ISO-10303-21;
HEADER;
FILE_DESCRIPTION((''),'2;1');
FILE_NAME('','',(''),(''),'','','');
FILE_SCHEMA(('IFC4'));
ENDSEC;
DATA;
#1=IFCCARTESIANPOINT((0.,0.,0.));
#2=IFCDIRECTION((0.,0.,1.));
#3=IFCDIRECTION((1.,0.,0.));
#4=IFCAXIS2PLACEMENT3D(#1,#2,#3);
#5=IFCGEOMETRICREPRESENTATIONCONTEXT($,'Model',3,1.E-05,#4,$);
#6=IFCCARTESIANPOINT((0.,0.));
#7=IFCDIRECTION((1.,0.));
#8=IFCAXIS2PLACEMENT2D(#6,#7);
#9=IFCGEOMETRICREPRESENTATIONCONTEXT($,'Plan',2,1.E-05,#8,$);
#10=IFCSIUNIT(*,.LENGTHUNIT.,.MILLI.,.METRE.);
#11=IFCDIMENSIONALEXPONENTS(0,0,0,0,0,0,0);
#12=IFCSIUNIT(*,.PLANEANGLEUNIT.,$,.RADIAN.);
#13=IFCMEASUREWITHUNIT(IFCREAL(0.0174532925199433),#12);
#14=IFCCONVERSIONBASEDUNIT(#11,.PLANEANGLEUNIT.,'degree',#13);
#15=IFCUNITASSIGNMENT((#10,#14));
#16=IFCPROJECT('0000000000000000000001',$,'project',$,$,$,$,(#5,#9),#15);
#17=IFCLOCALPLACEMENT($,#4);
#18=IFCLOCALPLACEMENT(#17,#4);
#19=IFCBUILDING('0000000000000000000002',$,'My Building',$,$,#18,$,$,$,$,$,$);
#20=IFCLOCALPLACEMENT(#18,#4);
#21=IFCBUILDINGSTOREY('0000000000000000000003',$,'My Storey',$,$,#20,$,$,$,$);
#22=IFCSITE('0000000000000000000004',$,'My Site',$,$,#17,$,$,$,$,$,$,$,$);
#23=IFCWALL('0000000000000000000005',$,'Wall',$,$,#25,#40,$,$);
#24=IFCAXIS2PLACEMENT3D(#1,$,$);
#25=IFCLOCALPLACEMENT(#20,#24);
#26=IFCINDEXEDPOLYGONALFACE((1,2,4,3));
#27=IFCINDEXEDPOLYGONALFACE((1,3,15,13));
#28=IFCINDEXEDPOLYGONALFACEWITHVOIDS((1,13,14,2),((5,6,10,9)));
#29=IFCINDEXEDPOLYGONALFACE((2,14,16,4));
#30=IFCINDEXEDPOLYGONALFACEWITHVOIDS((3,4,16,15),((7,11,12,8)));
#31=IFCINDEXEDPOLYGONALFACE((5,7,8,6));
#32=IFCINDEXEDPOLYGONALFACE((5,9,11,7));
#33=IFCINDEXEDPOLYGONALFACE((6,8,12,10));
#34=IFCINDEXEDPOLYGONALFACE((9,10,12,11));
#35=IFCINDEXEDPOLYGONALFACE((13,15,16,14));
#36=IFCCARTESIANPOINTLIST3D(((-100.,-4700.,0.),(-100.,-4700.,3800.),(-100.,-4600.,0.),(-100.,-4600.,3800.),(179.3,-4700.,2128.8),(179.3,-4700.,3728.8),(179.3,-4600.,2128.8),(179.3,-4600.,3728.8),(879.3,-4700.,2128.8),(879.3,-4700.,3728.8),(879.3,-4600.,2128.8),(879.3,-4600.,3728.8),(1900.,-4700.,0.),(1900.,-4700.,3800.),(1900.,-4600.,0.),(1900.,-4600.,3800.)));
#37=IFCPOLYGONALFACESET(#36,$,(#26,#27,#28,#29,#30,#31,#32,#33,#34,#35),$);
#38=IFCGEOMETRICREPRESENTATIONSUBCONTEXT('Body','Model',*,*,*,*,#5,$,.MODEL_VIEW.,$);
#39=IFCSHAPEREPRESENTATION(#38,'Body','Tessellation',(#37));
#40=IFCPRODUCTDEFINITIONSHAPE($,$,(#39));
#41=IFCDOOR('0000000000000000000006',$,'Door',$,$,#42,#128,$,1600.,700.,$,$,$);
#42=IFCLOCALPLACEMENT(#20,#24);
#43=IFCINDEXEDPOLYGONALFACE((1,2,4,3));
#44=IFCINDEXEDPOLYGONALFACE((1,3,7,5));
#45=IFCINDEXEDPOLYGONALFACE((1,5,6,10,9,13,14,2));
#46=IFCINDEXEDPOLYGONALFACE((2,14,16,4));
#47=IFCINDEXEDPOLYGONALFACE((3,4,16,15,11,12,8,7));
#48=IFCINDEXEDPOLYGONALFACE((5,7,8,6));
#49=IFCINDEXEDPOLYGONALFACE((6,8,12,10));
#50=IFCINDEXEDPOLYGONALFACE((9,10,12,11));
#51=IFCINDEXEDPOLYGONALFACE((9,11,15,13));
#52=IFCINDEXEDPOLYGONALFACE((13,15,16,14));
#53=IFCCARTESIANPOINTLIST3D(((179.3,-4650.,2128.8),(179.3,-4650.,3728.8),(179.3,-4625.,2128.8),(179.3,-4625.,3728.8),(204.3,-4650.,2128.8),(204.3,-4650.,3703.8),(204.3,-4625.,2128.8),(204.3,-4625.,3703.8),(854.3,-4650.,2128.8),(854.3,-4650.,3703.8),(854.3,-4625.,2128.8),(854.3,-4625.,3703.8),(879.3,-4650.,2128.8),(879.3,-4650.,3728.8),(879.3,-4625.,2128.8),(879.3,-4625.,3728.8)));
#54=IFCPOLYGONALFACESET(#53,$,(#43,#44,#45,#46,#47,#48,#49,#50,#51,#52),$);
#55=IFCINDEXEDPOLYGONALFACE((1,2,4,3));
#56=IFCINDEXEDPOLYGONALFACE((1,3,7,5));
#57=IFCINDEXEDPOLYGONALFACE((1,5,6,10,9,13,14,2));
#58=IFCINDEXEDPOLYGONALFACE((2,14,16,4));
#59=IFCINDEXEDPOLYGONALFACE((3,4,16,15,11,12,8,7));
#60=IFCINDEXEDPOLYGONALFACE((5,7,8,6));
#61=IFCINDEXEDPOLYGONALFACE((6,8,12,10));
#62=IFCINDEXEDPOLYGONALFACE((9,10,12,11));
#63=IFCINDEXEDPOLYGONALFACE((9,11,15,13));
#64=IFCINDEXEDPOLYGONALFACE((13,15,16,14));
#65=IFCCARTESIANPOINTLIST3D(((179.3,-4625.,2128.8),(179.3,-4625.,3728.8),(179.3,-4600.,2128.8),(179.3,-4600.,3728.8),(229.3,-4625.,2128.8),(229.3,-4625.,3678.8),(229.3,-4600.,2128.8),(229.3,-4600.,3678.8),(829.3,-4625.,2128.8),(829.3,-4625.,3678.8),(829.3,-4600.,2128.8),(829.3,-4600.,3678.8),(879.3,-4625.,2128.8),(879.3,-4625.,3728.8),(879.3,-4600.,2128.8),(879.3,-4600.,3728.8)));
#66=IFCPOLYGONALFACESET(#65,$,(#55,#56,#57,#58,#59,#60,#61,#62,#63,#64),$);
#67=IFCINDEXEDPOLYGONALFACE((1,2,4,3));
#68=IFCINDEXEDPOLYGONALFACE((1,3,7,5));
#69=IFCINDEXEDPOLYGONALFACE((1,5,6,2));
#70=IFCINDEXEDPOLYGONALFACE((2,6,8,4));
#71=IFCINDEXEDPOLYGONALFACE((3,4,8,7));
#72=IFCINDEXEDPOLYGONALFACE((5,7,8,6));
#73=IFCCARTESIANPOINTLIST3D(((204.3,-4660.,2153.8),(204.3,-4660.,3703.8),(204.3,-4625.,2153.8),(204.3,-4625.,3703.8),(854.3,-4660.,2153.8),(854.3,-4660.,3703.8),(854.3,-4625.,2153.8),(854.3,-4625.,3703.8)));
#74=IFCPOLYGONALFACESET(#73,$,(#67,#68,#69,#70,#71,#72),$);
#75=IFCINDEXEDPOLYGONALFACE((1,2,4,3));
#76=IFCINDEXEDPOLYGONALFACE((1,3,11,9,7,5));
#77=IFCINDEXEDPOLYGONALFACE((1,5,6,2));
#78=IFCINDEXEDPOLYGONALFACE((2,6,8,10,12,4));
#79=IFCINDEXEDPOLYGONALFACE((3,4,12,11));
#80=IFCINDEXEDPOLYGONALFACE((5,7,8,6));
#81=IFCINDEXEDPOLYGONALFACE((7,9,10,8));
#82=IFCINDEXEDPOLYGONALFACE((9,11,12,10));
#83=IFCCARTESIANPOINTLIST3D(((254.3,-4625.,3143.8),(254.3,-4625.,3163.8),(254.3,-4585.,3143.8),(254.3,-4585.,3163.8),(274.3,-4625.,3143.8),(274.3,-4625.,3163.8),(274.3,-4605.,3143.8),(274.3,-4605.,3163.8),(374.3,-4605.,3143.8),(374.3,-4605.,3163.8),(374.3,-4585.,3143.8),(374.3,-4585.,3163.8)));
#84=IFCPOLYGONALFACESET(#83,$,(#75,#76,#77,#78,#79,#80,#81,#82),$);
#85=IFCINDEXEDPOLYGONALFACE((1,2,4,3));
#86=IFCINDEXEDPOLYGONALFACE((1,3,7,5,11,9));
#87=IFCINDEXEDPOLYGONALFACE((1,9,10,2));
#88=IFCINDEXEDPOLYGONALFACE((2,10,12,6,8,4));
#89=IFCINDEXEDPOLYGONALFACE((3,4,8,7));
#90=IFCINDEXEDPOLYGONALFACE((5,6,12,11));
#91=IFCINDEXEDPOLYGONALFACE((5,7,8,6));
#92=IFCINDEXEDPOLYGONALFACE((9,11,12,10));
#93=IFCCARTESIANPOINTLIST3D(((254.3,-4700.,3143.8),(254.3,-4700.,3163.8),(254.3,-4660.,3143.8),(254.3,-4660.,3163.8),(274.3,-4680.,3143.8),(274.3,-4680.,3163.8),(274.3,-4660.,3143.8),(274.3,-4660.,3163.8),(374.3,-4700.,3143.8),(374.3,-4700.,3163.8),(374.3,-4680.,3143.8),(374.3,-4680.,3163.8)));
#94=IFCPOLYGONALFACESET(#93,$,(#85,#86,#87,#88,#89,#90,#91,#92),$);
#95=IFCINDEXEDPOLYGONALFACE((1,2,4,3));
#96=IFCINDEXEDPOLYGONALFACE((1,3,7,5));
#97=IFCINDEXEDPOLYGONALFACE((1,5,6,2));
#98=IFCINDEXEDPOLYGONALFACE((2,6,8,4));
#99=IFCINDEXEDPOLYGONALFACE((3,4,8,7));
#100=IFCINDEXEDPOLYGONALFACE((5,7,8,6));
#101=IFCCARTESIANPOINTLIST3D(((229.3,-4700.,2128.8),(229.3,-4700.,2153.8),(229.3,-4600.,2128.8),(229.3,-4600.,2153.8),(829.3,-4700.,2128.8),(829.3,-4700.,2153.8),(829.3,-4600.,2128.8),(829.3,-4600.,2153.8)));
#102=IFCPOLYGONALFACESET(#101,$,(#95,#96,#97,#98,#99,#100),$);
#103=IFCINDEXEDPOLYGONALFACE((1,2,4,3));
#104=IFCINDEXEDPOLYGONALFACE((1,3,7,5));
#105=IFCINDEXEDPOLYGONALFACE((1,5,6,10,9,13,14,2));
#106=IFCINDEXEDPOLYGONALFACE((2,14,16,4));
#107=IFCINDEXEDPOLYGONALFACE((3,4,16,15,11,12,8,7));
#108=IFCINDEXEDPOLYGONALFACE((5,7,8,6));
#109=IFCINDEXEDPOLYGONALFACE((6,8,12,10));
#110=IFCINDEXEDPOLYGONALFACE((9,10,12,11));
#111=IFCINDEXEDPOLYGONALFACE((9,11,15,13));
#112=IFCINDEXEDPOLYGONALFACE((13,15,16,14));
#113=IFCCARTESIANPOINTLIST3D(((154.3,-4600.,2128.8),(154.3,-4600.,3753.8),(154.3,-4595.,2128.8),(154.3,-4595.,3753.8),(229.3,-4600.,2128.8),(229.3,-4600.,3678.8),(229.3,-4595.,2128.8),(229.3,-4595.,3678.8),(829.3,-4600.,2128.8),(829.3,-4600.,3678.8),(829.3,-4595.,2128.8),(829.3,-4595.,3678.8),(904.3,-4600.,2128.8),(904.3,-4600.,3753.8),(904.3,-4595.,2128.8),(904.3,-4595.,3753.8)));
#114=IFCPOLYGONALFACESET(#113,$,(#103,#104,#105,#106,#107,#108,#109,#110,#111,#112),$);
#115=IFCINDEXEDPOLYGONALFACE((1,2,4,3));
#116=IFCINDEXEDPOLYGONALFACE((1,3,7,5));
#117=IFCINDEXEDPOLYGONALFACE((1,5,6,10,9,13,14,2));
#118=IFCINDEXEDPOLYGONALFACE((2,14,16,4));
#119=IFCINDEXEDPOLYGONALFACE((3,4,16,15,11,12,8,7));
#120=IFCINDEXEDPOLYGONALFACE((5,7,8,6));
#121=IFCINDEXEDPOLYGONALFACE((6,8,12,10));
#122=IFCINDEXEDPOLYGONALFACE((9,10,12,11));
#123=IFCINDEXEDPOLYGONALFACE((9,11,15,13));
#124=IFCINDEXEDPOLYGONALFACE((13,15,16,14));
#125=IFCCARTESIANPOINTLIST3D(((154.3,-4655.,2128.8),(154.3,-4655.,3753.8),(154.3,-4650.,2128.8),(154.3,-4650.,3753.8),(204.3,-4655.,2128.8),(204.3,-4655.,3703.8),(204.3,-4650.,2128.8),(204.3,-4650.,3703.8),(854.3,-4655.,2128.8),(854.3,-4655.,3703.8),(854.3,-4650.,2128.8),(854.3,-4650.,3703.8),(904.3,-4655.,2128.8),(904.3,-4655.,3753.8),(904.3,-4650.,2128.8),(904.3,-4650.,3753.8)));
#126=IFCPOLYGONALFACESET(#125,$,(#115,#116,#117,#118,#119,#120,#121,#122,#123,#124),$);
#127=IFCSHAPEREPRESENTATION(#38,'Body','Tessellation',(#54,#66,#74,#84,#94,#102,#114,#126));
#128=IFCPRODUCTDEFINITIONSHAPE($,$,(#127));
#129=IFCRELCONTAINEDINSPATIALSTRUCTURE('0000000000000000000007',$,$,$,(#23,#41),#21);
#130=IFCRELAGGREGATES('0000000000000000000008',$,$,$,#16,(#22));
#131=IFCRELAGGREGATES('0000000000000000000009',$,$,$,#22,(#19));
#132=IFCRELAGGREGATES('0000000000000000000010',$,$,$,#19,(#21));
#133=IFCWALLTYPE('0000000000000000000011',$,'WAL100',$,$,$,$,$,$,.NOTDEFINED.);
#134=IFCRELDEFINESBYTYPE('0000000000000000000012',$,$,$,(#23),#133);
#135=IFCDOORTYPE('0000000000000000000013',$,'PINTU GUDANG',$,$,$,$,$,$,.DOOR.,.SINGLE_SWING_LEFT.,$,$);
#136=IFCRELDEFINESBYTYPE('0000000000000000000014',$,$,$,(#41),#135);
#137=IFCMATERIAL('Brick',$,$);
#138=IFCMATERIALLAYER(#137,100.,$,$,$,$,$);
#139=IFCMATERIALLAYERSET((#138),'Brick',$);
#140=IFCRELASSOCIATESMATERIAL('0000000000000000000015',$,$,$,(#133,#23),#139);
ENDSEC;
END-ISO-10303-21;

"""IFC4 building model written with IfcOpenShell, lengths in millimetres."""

from ifc_helpers import new_model, entity, si_unit, converted_unit, frame, origin_with_axes, origin_2d_with_axis, place, context, subcontext, project, spatial, line, indexed_curve, outline, extrude, shape, source, transform, mapped, material, layer, layer_set, layer_usage, type_object, type_shapes, element, fill, save


model = new_model("IFC4")

# Units and contexts
model_context = context("Model", 3, precision=1e-05, world=origin_with_axes())
plan_context = context("Plan", 2, precision=1e-05, world=origin_2d_with_axis())
body_context_1 = subcontext(model_context, "Body", "Model", "MODEL_VIEW")
body_context_2 = subcontext(plan_context, "Body", "Plan", "PLAN_VIEW")
ifc_project = project(units=[si_unit("LENGTHUNIT", "METRE", prefix="MILLI"), converted_unit("PLANEANGLEUNIT", "degree", entity("IfcReal", 0.0174532925199433), si_unit("PLANEANGLEUNIT", "RADIAN"), dimensions=[0, 0, 0, 0, 0, 0, 0])], contexts=[model_context, plan_context])

# Site, building, storey
site_placement = place(None, origin_with_axes())
site = spatial("IfcSite", under=ifc_project, at=site_placement, Name="My Site")
building_placement = place(site_placement, origin_with_axes())
building = spatial("IfcBuilding", under=site, at=building_placement, Name="My Building")
storey_placement = place(building_placement, origin_with_axes())
storey = spatial("IfcBuildingStorey", under=building, at=storey_placement, Name="My Storey")

# Shared definitions
ifc_material = material(Name="Brick")
ifc_layer_1 = layer(ifc_material, 100.0)
ifc_layer_set_1 = layer_set([ifc_layer_1], Name="Brick")
wall_type = type_object("IfcWallType", Name="WAL100", PredefinedType="NOTDEFINED", material=ifc_layer_set_1)

# Wall, opening, door
ifc_layer_usage_1 = layer_usage(ifc_layer_set_1, "AXIS2", "POSITIVE", 0.0)
wall_1_placement = place(storey_placement, frame((1900.0, -4600.0, 0.0), z_axis=(0.0, 0.0, 1.0), x_axis=(-1.0, 0.000001, 0.0)))
wall_1 = element("IfcWall", 1, at=wall_1_placement, inside=storey, type_object=wall_type, material=ifc_layer_usage_1, Name="Wall", context=body_context_1, shape_type="SweptSolid", body=[
    extrude(outline(indexed_curve([(0.0, 0.0), (0.0, 100.0), (2000.0, 100.0), (2000.0, 0.0), (0.0, 0.0)], self_intersect=False)), origin_with_axes(), (0.0, 0.0, 1.0), 3800.0),
])
shared_shape_1 = source(origin_with_axes(), body_context_1, "Body", "SweptSolid", [
    extrude(outline(indexed_curve([(0.0, 0.0), (700.0, 0.0), (700.0, 1600.0), (0.0, 1600.0)], segments=[line(1, 2, 3, 4, 1)])), frame((0.0, -600.0, 0.0), z_axis=(0.0, -1.0, 0.0), x_axis=(1.0, 0.0, 0.0)), (0.0, 0.0, -1.0), 1200.0),
])
opening_1_placement = place(wall_1_placement, frame((1020.7, 0.0, 2128.8), z_axis=(0.0, 0.0, 1.0), x_axis=(1.0, 0.0, 0.0)))
opening_1 = element("IfcOpeningElement", 2, at=opening_1_placement, cuts=wall_1, PredefinedType="OPENING", context=body_context_1, shape_type="MappedRepresentation", body=[
    mapped(shared_shape_1, transform((0.0, 0.0, 0.0), x_axis=(1.0, 0.0, 0.0), y_axis=(0.0, 1.0, 0.0), z_axis=(0.0, 0.0, 1.0), scale=1.0)),
])
door_type_1 = type_object("IfcDoorType", Name="PINTU GUDANG", OperationType="SINGLE_SWING_LEFT", PredefinedType="DOOR")
shared_shape_2 = source(origin_with_axes(), body_context_1, "Body", "SweptSolid", [
    extrude(outline(indexed_curve([(0.0, 0.0), (0.0, 1600.0), (700.0, 1600.0), (700.0, 0.0), (675.0, 0.0), (675.0, 1575.0), (25.0, 1575.0), (25.0, 0.0)], segments=[line(1, 2, 3, 4, 5, 6, 7, 8, 1)])), frame((0.0, 25.0, 0.0), z_axis=(0.0, -1.0, 0.0), x_axis=(1.0, 0.0, 0.0)), (0.0, 0.0, -1.0), 25.0),
    extrude(outline(indexed_curve([(0.0, 0.0), (0.0, 1600.0), (700.0, 1600.0), (700.0, 0.0), (650.0, 0.0), (650.0, 1550.0), (50.0, 1550.0), (50.0, 0.0)], segments=[line(1, 2, 3, 4, 5, 6, 7, 8, 1)])), frame((0.0, 0.0, 0.0), z_axis=(0.0, -1.0, 0.0), x_axis=(1.0, 0.0, 0.0)), (0.0, 0.0, -1.0), 25.0),
    extrude(outline(indexed_curve([(0.0, 0.0), (650.0, 0.0), (650.0, 35.0), (0.0, 35.0)], segments=[line(1, 2, 3, 4, 1)])), frame((25.0, 25.0, 25.0), z_axis=(0.0, 0.0, 1.0), x_axis=(1.0, 0.0, 0.0)), (0.0, 0.0, 1.0), 1550.0),
    extrude(outline(indexed_curve([(0.0, 0.0), (0.0, -40.0), (-120.0, -40.0), (-120.0, -20.0), (-20.0, -20.0), (-20.0, 0.0)], segments=[line(1, 2, 3, 4, 5, 6, 1)])), frame((625.0, 25.0, 1015.0), z_axis=(0.0, 0.0, 1.0), x_axis=(1.0, 0.0, 0.0)), (0.0, 0.0, 1.0), 20.0),
    extrude(outline(indexed_curve([(0.0, 0.0), (0.0, 40.0), (-120.0, 40.0), (-120.0, 20.0), (-20.0, 20.0), (-20.0, 0.0)], segments=[line(1, 2, 3, 4, 5, 6, 1)])), frame((625.0, 60.0, 1015.0), z_axis=(0.0, 0.0, 1.0), x_axis=(1.0, 0.0, 0.0)), (0.0, 0.0, 1.0), 20.0),
    extrude(outline(indexed_curve([(0.0, 0.0), (600.0, 0.0), (600.0, 100.0), (0.0, 100.0)], segments=[line(1, 2, 3, 4, 1)])), frame((50.0, 0.0, 0.0), z_axis=(0.0, 0.0, 1.0), x_axis=(1.0, 0.0, 0.0)), (0.0, 0.0, 1.0), 25.0),
    extrude(outline(indexed_curve([(0.0, 0.0), (0.0, 1625.0), (750.0, 1625.0), (750.0, 0.0), (675.0, 0.0), (675.0, 1550.0), (75.0, 1550.0), (75.0, 0.0)], segments=[line(1, 2, 3, 4, 5, 6, 7, 8, 1)])), frame((-25.0, -5.0, 0.0), z_axis=(0.0, -1.0, 0.0), x_axis=(1.0, 0.0, 0.0)), (0.0, 0.0, -1.0), 5.0),
    extrude(outline(indexed_curve([(0.0, 0.0), (0.0, 1625.0), (750.0, 1625.0), (750.0, 0.0), (700.0, 0.0), (700.0, 1575.0), (50.0, 1575.0), (50.0, 0.0)], segments=[line(1, 2, 3, 4, 5, 6, 7, 8, 1)])), frame((-25.0, 50.0, 0.0), z_axis=(0.0, -1.0, 0.0), x_axis=(1.0, 0.0, 0.0)), (0.0, 0.0, -1.0), 5.0),
])
shared_shape_3 = source(origin_with_axes(), body_context_2, "Body", "Curve2D", [
    entity("IfcIndexedPolyCurve", entity("IfcCartesianPointList2D", [[0.0, 0.0], [0.0, 50.0], [25.0, 50.0], [25.0, 25.0], [50.0, 25.0], [50.0, 0.0]]), [entity("IfcLineIndex", [1, 2, 3, 4, 5, 6, 1])]),
    entity("IfcIndexedPolyCurve", entity("IfcCartesianPointList2D", [[700.0, 0.0], [700.0, 50.0], [675.0, 50.0], [675.0, 25.0], [650.0, 25.0], [650.0, 0.0]]), [entity("IfcLineIndex", [1, 2, 3, 4, 5, 6, 1])]),
    entity("IfcTrimmedCurve", entity("IfcEllipse", entity("IfcAxis2Placement2D", entity("IfcCartesianPoint", [60.0, 50.0]), entity("IfcDirection", [1.0, 0.0])), 615.0, 650.0), [entity("IfcCartesianPoint", [675.0, 50.0])], [entity("IfcCartesianPoint", [60.0, 700.0])], True, "CARTESIAN"),
    entity("IfcIndexedPolyCurve", entity("IfcCartesianPointList2D", [[25.0, 50.0], [60.0, 50.0], [60.0, 700.0], [25.0, 700.0]]), [entity("IfcLineIndex", [1, 2, 3, 4, 1])]),
])
type_shapes(door_type_1, [shared_shape_2, shared_shape_3])
door_1_placement = place(opening_1_placement, frame((0.0, 0.0, 0.0), z_axis=(0.0, 0.0, 1.0), x_axis=(1.0, 0.0, 0.0)))
door_1 = element("IfcDoor", 3, at=door_1_placement, inside=storey, type_object=door_type_1, Name="Door", OverallHeight=1600.0, OverallWidth=700.0, shapes=[
    shape(body_context_1, "Body", "MappedRepresentation", [mapped(shared_shape_2, transform((0.0, 0.0, 0.0), x_axis=(1.0, 0.0, 0.0), y_axis=(0.0, 1.0, 0.0), z_axis=(0.0, 0.0, 1.0), scale=1.0))]),
    shape(body_context_2, "Body", "MappedRepresentation", [mapped(shared_shape_3, transform((0.0, 0.0, 0.0), x_axis=(1.0, 0.0, 0.0), y_axis=(0.0, 1.0, 0.0), z_axis=(0.0, 0.0, 1.0), scale=1.0))]),
])
fill(opening_1, door_1)

save(model, "model.ifc")
